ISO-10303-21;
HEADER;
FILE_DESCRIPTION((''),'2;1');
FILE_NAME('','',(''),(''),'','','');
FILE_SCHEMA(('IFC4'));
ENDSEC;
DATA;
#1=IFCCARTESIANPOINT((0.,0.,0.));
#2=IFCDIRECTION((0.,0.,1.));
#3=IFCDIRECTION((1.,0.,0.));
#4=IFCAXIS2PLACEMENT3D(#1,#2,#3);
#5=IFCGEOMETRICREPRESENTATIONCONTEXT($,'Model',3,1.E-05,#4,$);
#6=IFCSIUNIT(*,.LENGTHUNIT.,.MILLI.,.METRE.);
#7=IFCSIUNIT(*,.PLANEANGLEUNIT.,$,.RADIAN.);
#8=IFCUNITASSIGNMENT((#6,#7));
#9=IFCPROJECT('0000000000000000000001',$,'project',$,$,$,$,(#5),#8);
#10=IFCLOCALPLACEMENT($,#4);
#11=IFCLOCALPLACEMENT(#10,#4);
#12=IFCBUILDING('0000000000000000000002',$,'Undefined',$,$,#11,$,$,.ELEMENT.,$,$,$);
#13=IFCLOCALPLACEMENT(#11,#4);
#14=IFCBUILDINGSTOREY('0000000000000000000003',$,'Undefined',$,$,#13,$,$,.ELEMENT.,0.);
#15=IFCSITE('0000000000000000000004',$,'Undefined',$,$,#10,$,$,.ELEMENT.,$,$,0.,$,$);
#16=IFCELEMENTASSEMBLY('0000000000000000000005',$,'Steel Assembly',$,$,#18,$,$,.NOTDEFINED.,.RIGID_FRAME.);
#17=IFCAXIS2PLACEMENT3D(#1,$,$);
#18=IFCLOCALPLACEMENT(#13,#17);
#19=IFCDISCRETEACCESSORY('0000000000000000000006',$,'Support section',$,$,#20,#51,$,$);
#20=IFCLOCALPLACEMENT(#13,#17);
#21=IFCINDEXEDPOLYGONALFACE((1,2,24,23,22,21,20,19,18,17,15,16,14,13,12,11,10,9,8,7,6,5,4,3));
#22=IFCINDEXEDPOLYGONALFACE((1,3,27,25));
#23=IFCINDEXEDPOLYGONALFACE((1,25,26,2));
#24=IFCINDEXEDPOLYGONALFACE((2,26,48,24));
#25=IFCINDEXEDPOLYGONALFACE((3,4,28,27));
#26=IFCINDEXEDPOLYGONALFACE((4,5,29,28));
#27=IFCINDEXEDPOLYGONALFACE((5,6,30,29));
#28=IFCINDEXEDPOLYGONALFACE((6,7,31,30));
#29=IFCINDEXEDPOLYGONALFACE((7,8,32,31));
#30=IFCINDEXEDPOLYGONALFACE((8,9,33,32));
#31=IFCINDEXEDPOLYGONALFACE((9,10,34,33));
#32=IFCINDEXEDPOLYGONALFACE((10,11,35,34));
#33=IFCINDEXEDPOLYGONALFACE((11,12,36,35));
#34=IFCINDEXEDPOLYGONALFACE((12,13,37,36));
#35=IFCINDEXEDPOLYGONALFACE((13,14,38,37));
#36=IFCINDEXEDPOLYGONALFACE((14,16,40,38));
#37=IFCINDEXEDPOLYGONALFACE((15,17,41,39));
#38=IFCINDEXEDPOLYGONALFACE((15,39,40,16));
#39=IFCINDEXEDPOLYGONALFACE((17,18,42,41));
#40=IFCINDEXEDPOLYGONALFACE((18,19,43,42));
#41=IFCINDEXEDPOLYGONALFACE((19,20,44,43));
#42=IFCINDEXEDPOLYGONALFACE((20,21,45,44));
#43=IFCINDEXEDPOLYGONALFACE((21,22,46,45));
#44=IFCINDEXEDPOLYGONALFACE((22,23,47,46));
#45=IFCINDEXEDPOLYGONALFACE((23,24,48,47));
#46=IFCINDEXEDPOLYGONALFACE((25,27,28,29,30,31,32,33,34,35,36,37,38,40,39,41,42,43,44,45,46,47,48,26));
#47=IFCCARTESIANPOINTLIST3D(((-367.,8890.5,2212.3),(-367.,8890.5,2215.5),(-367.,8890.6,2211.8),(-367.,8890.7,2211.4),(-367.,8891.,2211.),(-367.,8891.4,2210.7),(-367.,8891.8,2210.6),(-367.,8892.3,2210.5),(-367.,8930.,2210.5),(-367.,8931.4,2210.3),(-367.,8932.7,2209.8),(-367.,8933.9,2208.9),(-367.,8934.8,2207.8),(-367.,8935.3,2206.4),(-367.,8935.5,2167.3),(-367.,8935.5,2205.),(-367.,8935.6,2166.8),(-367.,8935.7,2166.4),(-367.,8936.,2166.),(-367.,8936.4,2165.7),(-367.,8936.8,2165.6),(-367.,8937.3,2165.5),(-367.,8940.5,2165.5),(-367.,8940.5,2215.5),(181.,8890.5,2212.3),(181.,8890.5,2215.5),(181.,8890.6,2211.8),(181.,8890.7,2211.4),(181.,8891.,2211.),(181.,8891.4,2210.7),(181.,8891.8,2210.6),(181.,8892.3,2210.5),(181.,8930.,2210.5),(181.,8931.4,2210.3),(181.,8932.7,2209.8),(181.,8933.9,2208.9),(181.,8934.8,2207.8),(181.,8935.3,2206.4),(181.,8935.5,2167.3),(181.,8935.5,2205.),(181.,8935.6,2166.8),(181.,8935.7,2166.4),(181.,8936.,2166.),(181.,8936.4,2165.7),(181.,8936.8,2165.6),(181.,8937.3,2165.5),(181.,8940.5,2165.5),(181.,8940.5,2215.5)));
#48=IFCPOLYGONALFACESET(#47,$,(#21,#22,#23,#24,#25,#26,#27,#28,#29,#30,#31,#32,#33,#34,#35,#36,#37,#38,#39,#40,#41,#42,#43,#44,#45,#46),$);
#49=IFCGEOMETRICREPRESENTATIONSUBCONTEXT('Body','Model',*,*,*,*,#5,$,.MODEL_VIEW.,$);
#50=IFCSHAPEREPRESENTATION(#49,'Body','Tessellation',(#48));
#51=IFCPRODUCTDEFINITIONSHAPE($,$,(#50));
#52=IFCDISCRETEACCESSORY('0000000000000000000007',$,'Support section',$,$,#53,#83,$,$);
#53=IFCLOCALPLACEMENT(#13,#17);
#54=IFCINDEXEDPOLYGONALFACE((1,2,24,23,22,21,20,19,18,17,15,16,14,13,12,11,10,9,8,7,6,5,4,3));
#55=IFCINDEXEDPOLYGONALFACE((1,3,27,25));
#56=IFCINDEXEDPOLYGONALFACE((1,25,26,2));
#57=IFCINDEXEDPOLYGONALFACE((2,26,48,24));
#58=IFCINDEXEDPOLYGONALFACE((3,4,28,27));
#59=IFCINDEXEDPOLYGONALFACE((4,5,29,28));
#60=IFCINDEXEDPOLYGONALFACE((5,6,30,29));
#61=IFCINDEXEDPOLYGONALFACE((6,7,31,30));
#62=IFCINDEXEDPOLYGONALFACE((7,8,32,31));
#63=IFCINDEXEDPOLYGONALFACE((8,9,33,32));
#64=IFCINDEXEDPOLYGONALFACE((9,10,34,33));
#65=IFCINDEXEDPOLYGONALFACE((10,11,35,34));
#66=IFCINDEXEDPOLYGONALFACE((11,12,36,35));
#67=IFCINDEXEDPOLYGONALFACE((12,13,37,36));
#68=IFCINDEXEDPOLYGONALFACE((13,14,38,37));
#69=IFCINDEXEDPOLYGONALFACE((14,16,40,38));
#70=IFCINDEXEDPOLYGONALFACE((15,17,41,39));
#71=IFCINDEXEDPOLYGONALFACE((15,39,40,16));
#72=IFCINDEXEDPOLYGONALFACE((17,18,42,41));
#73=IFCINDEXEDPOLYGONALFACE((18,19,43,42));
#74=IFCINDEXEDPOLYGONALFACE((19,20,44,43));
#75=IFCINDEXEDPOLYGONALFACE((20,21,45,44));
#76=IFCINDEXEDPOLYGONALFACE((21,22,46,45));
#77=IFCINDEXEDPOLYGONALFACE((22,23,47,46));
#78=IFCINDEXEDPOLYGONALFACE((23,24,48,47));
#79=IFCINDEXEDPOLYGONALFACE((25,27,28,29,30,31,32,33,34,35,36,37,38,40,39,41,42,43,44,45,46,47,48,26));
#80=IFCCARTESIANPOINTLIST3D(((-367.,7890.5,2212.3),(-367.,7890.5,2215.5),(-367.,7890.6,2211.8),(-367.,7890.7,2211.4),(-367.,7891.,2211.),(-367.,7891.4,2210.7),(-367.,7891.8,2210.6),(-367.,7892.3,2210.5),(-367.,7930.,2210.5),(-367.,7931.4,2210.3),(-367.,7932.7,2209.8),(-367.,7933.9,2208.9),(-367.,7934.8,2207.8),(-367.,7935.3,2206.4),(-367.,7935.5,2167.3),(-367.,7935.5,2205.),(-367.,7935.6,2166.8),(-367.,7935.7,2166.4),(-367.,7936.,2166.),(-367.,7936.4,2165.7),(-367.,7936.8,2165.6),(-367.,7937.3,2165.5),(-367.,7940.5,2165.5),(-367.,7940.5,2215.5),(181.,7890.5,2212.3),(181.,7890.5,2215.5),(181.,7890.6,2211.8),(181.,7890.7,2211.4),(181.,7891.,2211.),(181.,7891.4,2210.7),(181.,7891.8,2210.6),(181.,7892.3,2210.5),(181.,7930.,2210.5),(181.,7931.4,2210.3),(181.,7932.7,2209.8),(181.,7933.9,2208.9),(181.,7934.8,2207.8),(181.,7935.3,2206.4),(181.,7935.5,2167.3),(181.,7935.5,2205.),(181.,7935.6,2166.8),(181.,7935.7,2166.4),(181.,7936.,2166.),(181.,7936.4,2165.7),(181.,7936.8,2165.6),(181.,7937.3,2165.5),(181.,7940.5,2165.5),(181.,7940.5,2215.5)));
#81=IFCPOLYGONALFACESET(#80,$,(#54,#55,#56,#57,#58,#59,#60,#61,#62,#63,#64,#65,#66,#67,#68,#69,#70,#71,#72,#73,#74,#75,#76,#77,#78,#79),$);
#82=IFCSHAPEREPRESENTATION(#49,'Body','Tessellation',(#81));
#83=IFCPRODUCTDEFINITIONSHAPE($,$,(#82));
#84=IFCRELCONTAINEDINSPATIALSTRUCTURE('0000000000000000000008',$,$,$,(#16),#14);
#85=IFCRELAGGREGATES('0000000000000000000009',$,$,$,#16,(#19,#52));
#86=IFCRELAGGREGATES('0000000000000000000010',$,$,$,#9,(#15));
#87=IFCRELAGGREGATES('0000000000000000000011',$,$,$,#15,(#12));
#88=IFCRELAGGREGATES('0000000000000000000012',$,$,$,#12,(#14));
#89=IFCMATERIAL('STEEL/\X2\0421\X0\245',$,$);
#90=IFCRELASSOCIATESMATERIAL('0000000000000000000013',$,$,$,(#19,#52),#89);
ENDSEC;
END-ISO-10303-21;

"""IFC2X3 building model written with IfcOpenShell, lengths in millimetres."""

from ifc_helpers import new_model, si_unit, frame, origin_with_axes, origin_2d_with_axis, place, context, subcontext, project, spatial, l_section, extrude, material, element, aggregate, save


model = new_model("IFC2X3")

# Units and contexts
model_context = context("Model", 3, precision=1e-05, world=origin_with_axes())
body_context = subcontext(model_context, "Body", "Model", "MODEL_VIEW")
ifc_project = project(units=[si_unit("LENGTHUNIT", "METRE", prefix="MILLI"), si_unit("PLANEANGLEUNIT", "RADIAN")], contexts=[model_context])

# Site, building, storey
site_placement = place(None, origin_with_axes())
site = spatial("IfcSite", under=ifc_project, at=site_placement, Name="Undefined", CompositionType="ELEMENT", RefElevation=0.0)
building_placement = place(site_placement, origin_with_axes())
building = spatial("IfcBuilding", under=site, at=building_placement, Name="Undefined", CompositionType="ELEMENT")
storey_placement = place(building_placement, origin_with_axes())
storey = spatial("IfcBuildingStorey", under=building, at=storey_placement, Name="Undefined", CompositionType="ELEMENT", Elevation=0.0)

# Shared definitions
ifc_material_1 = material(Name="STEEL/С245")

# Element assembly
assembly_1_placement = place(storey_placement, origin_with_axes())
assembly_1 = element("IfcElementAssembly", 1, at=assembly_1_placement, inside=storey, Name="Steel Assembly", AssemblyPlace="NOTDEFINED", PredefinedType="RIGID_FRAME")

# Discrete accessories
discrete_accessory_1_placement = place(assembly_1_placement, frame((-367.0, 8915.5, 2190.5), z_axis=(0.0, -1.0, 0.0), x_axis=(1.0, 0.0, 0.0)))
discrete_accessory_1 = element("IfcDiscreteAccessory", 2, at=discrete_accessory_1_placement, material=ifc_material_1, Name="Support section", context=body_context, shape_type="SweptSolid", body=[
    extrude(l_section(Depth=50.0, Width=50.0, Thickness=5.0, FilletRadius=5.5, EdgeRadius=1.8, at=origin_2d_with_axis()), frame((548.0, 0.0, 0.0), z_axis=(-1.0, 0.0, 0.0), x_axis=(0.0, -1.0, 0.0)), (0.0, 0.0, 1.0), 548.0),
])
discrete_accessory_2_placement = place(assembly_1_placement, frame((-367.0, 7915.5, 2190.5), z_axis=(0.0, -1.0, 0.0), x_axis=(1.0, 0.0, 0.0)))
discrete_accessory_2 = element("IfcDiscreteAccessory", 3, at=discrete_accessory_2_placement, material=ifc_material_1, Name="Support section", context=body_context, shape_type="SweptSolid", body=[
    extrude(l_section(Depth=50.0, Width=50.0, Thickness=5.0, FilletRadius=5.5, EdgeRadius=1.8, at=origin_2d_with_axis()), frame((548.0, 0.0, 0.0), z_axis=(-1.0, 0.0, 0.0), x_axis=(0.0, -1.0, 0.0)), (0.0, 0.0, 1.0), 548.0),
])
aggregate(assembly_1, [discrete_accessory_1, discrete_accessory_2])

save(model, "model.ifc")
